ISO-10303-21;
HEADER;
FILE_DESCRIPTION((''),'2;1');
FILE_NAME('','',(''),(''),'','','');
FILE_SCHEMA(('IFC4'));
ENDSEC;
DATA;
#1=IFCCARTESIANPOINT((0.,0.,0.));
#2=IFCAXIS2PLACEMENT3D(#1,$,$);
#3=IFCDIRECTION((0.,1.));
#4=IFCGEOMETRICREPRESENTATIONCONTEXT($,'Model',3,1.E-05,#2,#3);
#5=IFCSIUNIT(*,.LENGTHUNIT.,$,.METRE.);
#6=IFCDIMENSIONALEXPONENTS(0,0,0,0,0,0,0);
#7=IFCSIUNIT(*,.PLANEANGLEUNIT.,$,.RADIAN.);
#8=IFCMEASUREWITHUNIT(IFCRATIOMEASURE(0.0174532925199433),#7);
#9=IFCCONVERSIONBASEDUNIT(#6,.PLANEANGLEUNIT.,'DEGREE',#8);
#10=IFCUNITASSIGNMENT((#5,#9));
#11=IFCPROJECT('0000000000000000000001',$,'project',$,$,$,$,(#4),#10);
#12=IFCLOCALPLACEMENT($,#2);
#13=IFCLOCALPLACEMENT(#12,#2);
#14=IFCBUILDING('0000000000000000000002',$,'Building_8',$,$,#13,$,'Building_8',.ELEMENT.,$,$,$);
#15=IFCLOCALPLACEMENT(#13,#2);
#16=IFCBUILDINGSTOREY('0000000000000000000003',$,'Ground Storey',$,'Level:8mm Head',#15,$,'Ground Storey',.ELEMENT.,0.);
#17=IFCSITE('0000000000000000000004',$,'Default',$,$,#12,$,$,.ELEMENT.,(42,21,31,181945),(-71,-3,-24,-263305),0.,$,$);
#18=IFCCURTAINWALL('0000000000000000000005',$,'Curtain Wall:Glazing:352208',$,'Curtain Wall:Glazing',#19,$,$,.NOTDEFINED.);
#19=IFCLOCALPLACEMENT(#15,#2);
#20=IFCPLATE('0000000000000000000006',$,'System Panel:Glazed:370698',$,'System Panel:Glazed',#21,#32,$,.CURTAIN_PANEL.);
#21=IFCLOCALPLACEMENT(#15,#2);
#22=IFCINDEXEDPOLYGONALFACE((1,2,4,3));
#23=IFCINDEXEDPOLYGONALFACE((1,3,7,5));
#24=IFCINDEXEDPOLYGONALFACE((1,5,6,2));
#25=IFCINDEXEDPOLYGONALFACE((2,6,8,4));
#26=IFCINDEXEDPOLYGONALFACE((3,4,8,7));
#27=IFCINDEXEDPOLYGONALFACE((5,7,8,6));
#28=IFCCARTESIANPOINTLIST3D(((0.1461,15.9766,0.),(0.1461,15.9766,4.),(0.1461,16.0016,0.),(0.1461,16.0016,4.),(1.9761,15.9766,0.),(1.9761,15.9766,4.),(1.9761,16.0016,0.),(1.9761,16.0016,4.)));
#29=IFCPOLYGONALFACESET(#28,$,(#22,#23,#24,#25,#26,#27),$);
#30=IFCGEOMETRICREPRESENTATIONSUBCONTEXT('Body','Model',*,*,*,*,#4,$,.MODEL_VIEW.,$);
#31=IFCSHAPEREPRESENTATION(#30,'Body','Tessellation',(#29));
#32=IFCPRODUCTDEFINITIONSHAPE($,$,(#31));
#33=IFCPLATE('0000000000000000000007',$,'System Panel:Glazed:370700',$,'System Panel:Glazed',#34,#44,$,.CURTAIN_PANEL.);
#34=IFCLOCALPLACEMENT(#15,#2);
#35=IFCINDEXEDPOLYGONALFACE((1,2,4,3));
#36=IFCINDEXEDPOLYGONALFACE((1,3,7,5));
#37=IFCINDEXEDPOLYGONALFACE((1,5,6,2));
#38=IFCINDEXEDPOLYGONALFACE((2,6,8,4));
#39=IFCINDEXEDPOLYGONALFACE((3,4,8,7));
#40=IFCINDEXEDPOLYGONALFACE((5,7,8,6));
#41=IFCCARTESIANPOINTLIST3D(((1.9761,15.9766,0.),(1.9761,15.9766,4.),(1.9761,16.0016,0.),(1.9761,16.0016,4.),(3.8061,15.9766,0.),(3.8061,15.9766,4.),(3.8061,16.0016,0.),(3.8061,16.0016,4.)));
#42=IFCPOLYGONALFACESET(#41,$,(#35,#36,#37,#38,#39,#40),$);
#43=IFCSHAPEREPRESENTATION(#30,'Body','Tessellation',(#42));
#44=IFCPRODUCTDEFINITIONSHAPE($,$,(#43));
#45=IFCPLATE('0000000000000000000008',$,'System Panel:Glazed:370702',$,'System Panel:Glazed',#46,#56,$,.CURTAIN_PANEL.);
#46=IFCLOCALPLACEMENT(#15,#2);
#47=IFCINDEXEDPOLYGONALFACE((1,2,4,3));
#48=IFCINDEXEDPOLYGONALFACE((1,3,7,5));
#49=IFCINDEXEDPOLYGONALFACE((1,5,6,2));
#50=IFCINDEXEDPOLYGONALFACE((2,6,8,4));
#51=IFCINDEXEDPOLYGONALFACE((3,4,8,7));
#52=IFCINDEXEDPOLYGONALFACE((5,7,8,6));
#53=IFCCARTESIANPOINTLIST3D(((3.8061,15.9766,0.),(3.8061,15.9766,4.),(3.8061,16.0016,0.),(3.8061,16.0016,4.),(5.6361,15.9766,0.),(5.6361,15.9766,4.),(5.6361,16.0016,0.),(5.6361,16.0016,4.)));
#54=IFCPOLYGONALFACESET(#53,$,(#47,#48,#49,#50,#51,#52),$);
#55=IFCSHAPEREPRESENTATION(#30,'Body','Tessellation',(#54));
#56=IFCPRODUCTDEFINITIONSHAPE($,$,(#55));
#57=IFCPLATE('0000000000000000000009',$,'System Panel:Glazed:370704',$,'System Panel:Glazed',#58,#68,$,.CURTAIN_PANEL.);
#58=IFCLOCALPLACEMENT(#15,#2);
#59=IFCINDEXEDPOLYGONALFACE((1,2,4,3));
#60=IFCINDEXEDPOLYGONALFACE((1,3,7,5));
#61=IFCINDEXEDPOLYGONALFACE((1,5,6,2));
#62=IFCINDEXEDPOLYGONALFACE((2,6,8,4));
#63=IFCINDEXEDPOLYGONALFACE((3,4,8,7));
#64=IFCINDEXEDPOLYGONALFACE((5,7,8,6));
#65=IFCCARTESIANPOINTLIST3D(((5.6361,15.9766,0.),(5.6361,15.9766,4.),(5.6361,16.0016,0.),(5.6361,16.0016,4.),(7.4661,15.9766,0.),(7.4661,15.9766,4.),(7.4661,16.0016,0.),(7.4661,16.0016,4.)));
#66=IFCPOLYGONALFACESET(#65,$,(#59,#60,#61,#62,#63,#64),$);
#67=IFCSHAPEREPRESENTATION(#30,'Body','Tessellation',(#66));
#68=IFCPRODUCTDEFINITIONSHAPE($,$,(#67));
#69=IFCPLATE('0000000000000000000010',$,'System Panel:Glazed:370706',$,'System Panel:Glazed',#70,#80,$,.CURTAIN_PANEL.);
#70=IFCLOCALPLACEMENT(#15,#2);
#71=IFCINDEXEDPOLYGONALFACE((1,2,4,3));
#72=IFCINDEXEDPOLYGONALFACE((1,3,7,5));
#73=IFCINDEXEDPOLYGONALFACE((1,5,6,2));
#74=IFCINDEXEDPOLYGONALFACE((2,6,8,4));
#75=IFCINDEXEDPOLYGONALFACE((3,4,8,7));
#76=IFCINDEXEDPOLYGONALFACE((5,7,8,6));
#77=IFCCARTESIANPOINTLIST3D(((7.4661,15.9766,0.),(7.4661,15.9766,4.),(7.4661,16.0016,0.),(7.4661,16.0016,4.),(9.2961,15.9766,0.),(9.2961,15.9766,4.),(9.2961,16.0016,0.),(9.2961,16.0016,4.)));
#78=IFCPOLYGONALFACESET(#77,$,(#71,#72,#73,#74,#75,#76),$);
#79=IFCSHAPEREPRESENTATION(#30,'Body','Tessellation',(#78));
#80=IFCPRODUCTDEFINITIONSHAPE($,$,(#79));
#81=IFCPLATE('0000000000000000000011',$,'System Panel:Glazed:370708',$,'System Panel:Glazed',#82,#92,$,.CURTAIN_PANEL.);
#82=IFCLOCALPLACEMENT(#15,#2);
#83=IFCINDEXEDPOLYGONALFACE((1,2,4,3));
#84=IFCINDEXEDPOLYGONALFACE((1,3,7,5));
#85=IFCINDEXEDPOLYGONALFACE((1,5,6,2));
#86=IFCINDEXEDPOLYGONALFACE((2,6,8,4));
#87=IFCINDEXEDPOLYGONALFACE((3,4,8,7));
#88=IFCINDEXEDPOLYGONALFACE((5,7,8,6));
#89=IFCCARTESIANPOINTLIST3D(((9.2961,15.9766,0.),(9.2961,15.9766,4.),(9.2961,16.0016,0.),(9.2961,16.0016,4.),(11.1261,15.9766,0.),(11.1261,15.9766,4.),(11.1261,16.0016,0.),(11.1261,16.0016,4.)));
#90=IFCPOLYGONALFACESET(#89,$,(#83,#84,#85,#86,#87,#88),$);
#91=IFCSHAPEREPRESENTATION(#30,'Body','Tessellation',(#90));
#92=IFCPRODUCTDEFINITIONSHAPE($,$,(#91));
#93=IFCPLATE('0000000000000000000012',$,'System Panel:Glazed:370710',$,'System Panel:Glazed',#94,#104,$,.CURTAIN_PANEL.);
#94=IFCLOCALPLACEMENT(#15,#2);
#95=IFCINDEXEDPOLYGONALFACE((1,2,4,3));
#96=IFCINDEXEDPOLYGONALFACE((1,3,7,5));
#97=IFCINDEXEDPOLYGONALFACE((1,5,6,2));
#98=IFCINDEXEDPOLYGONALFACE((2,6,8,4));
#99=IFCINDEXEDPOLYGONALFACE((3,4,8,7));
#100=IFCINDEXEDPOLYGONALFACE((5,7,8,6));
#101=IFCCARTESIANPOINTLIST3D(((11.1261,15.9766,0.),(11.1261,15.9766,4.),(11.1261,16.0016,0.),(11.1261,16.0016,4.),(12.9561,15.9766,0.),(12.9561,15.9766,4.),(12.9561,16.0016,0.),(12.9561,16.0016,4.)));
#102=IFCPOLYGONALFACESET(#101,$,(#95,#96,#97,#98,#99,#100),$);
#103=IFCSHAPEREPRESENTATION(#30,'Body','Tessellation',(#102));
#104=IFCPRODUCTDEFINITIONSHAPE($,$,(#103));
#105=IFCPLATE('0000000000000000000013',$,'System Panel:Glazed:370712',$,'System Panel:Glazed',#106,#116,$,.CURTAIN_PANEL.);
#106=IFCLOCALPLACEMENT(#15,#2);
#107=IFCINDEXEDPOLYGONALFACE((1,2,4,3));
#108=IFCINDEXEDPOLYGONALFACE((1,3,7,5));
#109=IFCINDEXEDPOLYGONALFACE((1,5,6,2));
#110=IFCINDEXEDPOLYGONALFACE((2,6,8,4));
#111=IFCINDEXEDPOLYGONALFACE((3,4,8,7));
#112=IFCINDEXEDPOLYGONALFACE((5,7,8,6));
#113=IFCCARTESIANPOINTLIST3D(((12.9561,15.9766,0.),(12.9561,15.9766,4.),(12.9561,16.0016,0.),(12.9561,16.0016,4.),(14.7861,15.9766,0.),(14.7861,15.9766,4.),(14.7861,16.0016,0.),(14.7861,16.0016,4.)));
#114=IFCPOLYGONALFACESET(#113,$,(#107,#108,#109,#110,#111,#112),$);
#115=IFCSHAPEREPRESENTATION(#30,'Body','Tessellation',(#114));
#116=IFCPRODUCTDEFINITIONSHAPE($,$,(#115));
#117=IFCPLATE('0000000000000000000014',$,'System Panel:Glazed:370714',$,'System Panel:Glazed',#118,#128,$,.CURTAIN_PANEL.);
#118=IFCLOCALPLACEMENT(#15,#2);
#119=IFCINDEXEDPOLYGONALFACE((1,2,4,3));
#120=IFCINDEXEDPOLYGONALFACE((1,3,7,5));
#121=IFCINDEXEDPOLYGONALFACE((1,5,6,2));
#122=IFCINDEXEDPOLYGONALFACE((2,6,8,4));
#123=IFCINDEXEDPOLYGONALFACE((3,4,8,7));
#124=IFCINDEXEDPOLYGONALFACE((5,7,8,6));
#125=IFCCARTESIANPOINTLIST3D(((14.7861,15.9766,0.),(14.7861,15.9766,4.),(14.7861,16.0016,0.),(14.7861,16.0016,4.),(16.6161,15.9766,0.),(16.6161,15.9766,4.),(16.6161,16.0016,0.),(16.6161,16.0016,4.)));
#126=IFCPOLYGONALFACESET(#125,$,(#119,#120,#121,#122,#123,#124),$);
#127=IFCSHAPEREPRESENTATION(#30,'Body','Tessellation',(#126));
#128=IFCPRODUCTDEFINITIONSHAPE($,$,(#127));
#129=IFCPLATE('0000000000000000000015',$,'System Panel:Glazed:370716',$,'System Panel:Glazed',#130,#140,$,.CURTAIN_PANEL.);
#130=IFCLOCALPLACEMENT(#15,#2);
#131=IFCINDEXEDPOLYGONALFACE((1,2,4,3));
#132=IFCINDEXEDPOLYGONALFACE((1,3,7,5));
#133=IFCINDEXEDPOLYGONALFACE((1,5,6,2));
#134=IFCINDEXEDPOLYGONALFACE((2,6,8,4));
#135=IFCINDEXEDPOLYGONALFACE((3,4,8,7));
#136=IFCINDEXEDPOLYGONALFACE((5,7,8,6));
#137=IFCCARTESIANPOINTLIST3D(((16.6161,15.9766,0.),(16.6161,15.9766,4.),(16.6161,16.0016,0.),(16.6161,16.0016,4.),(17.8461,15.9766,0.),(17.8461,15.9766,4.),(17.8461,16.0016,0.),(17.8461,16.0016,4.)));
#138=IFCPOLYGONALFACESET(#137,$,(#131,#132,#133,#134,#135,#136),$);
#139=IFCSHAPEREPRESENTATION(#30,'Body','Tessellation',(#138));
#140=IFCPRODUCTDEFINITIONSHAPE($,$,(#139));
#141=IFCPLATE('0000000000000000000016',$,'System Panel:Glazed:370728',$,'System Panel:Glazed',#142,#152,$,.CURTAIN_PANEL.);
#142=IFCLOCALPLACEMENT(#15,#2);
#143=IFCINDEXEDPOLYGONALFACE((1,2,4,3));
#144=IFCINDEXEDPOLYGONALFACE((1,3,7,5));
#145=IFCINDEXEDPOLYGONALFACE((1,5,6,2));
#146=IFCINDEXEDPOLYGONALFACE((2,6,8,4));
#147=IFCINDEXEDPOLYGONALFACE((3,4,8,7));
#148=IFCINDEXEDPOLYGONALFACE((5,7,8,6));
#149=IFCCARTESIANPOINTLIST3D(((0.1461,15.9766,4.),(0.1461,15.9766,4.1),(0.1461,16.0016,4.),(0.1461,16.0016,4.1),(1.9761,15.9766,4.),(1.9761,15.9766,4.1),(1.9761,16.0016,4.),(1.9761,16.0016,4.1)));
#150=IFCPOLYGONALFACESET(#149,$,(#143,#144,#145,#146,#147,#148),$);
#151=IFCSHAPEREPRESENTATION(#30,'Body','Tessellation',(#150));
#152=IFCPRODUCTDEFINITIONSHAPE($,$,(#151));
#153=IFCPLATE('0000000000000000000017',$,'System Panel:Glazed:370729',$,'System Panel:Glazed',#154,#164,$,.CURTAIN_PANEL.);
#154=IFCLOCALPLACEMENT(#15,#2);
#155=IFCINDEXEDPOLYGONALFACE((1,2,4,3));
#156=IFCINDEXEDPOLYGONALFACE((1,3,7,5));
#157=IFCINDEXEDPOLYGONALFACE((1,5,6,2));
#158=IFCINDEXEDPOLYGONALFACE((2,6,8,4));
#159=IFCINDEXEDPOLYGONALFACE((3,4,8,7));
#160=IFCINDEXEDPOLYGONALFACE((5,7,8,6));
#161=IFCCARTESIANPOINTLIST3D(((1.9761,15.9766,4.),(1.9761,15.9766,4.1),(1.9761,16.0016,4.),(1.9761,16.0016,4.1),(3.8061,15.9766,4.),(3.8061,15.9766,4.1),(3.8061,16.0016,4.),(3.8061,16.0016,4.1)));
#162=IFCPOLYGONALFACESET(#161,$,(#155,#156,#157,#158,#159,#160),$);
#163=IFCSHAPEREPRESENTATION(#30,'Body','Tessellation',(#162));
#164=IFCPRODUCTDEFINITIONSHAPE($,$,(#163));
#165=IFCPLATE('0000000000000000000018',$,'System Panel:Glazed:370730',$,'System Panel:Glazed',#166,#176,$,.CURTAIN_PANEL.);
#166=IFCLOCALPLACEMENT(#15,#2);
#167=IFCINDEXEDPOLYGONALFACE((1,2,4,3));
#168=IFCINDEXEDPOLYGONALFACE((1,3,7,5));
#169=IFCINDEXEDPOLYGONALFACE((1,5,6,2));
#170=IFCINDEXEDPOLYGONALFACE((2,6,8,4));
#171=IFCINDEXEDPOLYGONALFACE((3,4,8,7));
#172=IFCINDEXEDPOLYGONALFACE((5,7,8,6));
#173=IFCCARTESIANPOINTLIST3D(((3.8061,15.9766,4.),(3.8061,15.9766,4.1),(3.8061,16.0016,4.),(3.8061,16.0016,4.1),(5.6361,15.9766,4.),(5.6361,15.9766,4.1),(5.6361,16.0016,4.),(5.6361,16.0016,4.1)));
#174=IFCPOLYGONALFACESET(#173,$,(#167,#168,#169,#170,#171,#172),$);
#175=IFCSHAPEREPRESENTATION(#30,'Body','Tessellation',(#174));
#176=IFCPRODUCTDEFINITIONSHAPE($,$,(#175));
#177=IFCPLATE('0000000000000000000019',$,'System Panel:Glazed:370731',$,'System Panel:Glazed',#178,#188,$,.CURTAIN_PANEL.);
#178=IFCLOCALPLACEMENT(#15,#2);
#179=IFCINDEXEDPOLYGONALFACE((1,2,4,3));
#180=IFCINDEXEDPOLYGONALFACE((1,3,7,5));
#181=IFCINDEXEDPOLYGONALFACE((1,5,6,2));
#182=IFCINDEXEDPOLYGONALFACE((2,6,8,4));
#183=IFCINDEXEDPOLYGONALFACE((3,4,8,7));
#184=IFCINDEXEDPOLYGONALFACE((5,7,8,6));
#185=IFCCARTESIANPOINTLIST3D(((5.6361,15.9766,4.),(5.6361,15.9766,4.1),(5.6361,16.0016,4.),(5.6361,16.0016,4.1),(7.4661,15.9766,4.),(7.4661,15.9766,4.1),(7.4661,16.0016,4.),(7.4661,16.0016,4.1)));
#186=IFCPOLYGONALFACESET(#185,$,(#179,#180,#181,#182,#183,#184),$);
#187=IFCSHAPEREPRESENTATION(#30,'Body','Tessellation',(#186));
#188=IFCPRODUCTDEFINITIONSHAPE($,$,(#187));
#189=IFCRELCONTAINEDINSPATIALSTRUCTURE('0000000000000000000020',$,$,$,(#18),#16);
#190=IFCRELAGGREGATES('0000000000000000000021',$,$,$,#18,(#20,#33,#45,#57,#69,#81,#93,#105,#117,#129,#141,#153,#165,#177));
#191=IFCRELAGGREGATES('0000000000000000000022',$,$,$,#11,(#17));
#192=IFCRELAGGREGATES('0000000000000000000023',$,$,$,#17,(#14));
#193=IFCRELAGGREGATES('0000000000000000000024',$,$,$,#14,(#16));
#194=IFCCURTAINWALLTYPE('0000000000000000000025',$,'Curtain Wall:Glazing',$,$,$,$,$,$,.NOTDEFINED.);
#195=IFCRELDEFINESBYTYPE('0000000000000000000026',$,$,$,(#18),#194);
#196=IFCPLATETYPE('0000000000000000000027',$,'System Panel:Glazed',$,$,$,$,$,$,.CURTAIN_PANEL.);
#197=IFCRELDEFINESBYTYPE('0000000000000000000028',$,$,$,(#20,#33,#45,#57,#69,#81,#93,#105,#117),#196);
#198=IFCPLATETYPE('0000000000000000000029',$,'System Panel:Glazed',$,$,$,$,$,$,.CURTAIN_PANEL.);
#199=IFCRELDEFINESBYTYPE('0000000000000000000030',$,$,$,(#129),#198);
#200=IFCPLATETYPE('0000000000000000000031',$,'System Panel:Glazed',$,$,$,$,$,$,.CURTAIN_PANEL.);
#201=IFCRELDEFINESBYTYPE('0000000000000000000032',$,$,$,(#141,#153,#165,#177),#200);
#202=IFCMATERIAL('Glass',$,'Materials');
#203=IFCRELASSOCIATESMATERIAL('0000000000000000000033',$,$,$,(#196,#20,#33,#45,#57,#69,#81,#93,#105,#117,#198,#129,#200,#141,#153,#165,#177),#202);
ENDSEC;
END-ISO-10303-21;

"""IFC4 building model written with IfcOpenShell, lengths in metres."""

from ifc_helpers import new_model, entity, si_unit, converted_unit, direction, frame, origin, place, context, subcontext, project, spatial, indexed_curve, outline, extrude, source, transform, mapped, material, type_object, type_shapes, element, aggregate, save


model = new_model("IFC4")

# Units and contexts
model_context = context("Model", 3, precision=1e-05, world=origin(), true_north=direction((0.0, 1.0)))
body_context = subcontext(model_context, "Body", "Model", "MODEL_VIEW")
ifc_project = project(units=[si_unit("LENGTHUNIT", "METRE"), converted_unit("PLANEANGLEUNIT", "DEGREE", entity("IfcRatioMeasure", 0.0174532925199433), si_unit("PLANEANGLEUNIT", "RADIAN"), dimensions=[0, 0, 0, 0, 0, 0, 0])], contexts=[model_context])

# Site, building, storey
site_placement = place(None, origin())
site = spatial("IfcSite", under=ifc_project, at=site_placement, Name="Default", CompositionType="ELEMENT", RefLatitude=(42, 21, 31, 181945), RefLongitude=(-71, -3, -24, -263305), RefElevation=0.0)
building_placement = place(site_placement, origin())
building = spatial("IfcBuilding", under=site, at=building_placement, Name="Building_8", LongName="Building_8", CompositionType="ELEMENT")
storey_placement = place(building_placement, origin())
storey = spatial("IfcBuildingStorey", under=building, at=storey_placement, Name="Ground Storey", ObjectType="Level:8mm Head", LongName="Ground Storey", CompositionType="ELEMENT", Elevation=0.0)

# Curtain wall, plates
curtain_wall_type = type_object("IfcCurtainWallType", Name="Curtain Wall:Glazing", PredefinedType="NOTDEFINED")
curtain_wall_placement = place(storey_placement, origin())
curtain_wall = element("IfcCurtainWall", 1, at=curtain_wall_placement, inside=storey, type_object=curtain_wall_type, Name="Curtain Wall:Glazing:352208", ObjectType="Curtain Wall:Glazing", PredefinedType="NOTDEFINED")
ifc_material_1 = material(Name="Glass", Category="Materials")
plate_type_1 = type_object("IfcPlateType", Name="System Panel:Glazed", PredefinedType="CURTAIN_PANEL", material=ifc_material_1)
shared_shape_1 = source(origin(), body_context, "Body", "SweptSolid", [
    extrude(outline(indexed_curve([(-0.0125, -0.915), (0.0125, -0.915), (0.0125, 0.915), (-0.0125, 0.915), (-0.0125, -0.915)], self_intersect=False)), frame((0.0, 0.037, 0.0), z_axis=(0.0, 0.0, 1.0), x_axis=(0.0, 1.0, 0.0)), (0.0, 0.0, 1.0), 4.0),
])
type_shapes(plate_type_1, [shared_shape_1])
plate_1_placement = place(curtain_wall_placement, frame((1.0611, 15.9521, 0.0)))
plate_1 = element("IfcPlate", 2, at=plate_1_placement, type_object=plate_type_1, material=ifc_material_1, Name="System Panel:Glazed:370698", ObjectType="System Panel:Glazed", PredefinedType="CURTAIN_PANEL", context=body_context, shape_type="MappedRepresentation", body=[
    mapped(shared_shape_1, transform((0.0, 0.0, 0.0), scale=1.0)),
])
plate_2_placement = place(curtain_wall_placement, frame((2.8911, 15.9521, 0.0)))
plate_2 = element("IfcPlate", 3, at=plate_2_placement, type_object=plate_type_1, material=ifc_material_1, Name="System Panel:Glazed:370700", ObjectType="System Panel:Glazed", PredefinedType="CURTAIN_PANEL", context=body_context, shape_type="MappedRepresentation", body=[
    mapped(shared_shape_1, transform((0.0, 0.0, 0.0), scale=1.0)),
])
plate_3_placement = place(curtain_wall_placement, frame((4.7211, 15.9521, 0.0)))
plate_3 = element("IfcPlate", 4, at=plate_3_placement, type_object=plate_type_1, material=ifc_material_1, Name="System Panel:Glazed:370702", ObjectType="System Panel:Glazed", PredefinedType="CURTAIN_PANEL", context=body_context, shape_type="MappedRepresentation", body=[
    mapped(shared_shape_1, transform((0.0, 0.0, 0.0), scale=1.0)),
])
plate_4_placement = place(curtain_wall_placement, frame((6.5511, 15.9521, 0.0)))
plate_4 = element("IfcPlate", 5, at=plate_4_placement, type_object=plate_type_1, material=ifc_material_1, Name="System Panel:Glazed:370704", ObjectType="System Panel:Glazed", PredefinedType="CURTAIN_PANEL", context=body_context, shape_type="MappedRepresentation", body=[
    mapped(shared_shape_1, transform((0.0, 0.0, 0.0), scale=1.0)),
])
plate_5_placement = place(curtain_wall_placement, frame((8.3811, 15.9521, 0.0)))
plate_5 = element("IfcPlate", 6, at=plate_5_placement, type_object=plate_type_1, material=ifc_material_1, Name="System Panel:Glazed:370706", ObjectType="System Panel:Glazed", PredefinedType="CURTAIN_PANEL", context=body_context, shape_type="MappedRepresentation", body=[
    mapped(shared_shape_1, transform((0.0, 0.0, 0.0), scale=1.0)),
])
plate_6_placement = place(curtain_wall_placement, frame((10.2111, 15.9521, 0.0)))
plate_6 = element("IfcPlate", 7, at=plate_6_placement, type_object=plate_type_1, material=ifc_material_1, Name="System Panel:Glazed:370708", ObjectType="System Panel:Glazed", PredefinedType="CURTAIN_PANEL", context=body_context, shape_type="MappedRepresentation", body=[
    mapped(shared_shape_1, transform((0.0, 0.0, 0.0), scale=1.0)),
])
plate_7_placement = place(curtain_wall_placement, frame((12.0411, 15.9521, 0.0)))
plate_7 = element("IfcPlate", 8, at=plate_7_placement, type_object=plate_type_1, material=ifc_material_1, Name="System Panel:Glazed:370710", ObjectType="System Panel:Glazed", PredefinedType="CURTAIN_PANEL", context=body_context, shape_type="MappedRepresentation", body=[
    mapped(shared_shape_1, transform((0.0, 0.0, 0.0), scale=1.0)),
])
plate_8_placement = place(curtain_wall_placement, frame((13.8711, 15.9521, 0.0)))
plate_8 = element("IfcPlate", 9, at=plate_8_placement, type_object=plate_type_1, material=ifc_material_1, Name="System Panel:Glazed:370712", ObjectType="System Panel:Glazed", PredefinedType="CURTAIN_PANEL", context=body_context, shape_type="MappedRepresentation", body=[
    mapped(shared_shape_1, transform((0.0, 0.0, 0.0), scale=1.0)),
])
plate_9_placement = place(curtain_wall_placement, frame((15.7011, 15.9521, 0.0)))
plate_9 = element("IfcPlate", 10, at=plate_9_placement, type_object=plate_type_1, material=ifc_material_1, Name="System Panel:Glazed:370714", ObjectType="System Panel:Glazed", PredefinedType="CURTAIN_PANEL", context=body_context, shape_type="MappedRepresentation", body=[
    mapped(shared_shape_1, transform((0.0, 0.0, 0.0), scale=1.0)),
])
plate_type_2 = type_object("IfcPlateType", Name="System Panel:Glazed", PredefinedType="CURTAIN_PANEL", material=ifc_material_1)
shared_shape_2 = source(origin(), body_context, "Body", "SweptSolid", [
    extrude(outline(indexed_curve([(-0.0125, -0.615), (0.0125, -0.615), (0.0125, 0.615), (-0.0125, 0.615), (-0.0125, -0.615)], self_intersect=False)), frame((0.0, 0.037, 0.0), z_axis=(0.0, 0.0, 1.0), x_axis=(0.0, 1.0, 0.0)), (0.0, 0.0, 1.0), 4.0),
])
type_shapes(plate_type_2, [shared_shape_2])
plate_10_placement = place(curtain_wall_placement, frame((17.2311, 15.9521, 0.0)))
plate_10 = element("IfcPlate", 11, at=plate_10_placement, type_object=plate_type_2, material=ifc_material_1, Name="System Panel:Glazed:370716", ObjectType="System Panel:Glazed", PredefinedType="CURTAIN_PANEL", context=body_context, shape_type="MappedRepresentation", body=[
    mapped(shared_shape_2, transform((0.0, 0.0, 0.0), scale=1.0)),
])
plate_type_3 = type_object("IfcPlateType", Name="System Panel:Glazed", PredefinedType="CURTAIN_PANEL", material=ifc_material_1)
shared_shape_3 = source(origin(), body_context, "Body", "SweptSolid", [
    extrude(outline(indexed_curve([(-0.0125, -0.915), (0.0125, -0.915), (0.0125, 0.915), (-0.0125, 0.915), (-0.0125, -0.915)], self_intersect=False)), frame((0.0, 0.037, 0.0), z_axis=(0.0, 0.0, 1.0), x_axis=(0.0, 1.0, 0.0)), (0.0, 0.0, 1.0), 0.1),
])
type_shapes(plate_type_3, [shared_shape_3])
plate_11_placement = place(curtain_wall_placement, frame((1.0611, 15.9521, 4.0)))
plate_11 = element("IfcPlate", 12, at=plate_11_placement, type_object=plate_type_3, material=ifc_material_1, Name="System Panel:Glazed:370728", ObjectType="System Panel:Glazed", PredefinedType="CURTAIN_PANEL", context=body_context, shape_type="MappedRepresentation", body=[
    mapped(shared_shape_3, transform((0.0, 0.0, 0.0), scale=1.0)),
])
plate_12_placement = place(curtain_wall_placement, frame((2.8911, 15.9521, 4.0)))
plate_12 = element("IfcPlate", 13, at=plate_12_placement, type_object=plate_type_3, material=ifc_material_1, Name="System Panel:Glazed:370729", ObjectType="System Panel:Glazed", PredefinedType="CURTAIN_PANEL", context=body_context, shape_type="MappedRepresentation", body=[
    mapped(shared_shape_3, transform((0.0, 0.0, 0.0), scale=1.0)),
])
plate_13_placement = place(curtain_wall_placement, frame((4.7211, 15.9521, 4.0)))
plate_13 = element("IfcPlate", 14, at=plate_13_placement, type_object=plate_type_3, material=ifc_material_1, Name="System Panel:Glazed:370730", ObjectType="System Panel:Glazed", PredefinedType="CURTAIN_PANEL", context=body_context, shape_type="MappedRepresentation", body=[
    mapped(shared_shape_3, transform((0.0, 0.0, 0.0), scale=1.0)),
])
plate_14_placement = place(curtain_wall_placement, frame((6.5511, 15.9521, 4.0)))
plate_14 = element("IfcPlate", 15, at=plate_14_placement, type_object=plate_type_3, material=ifc_material_1, Name="System Panel:Glazed:370731", ObjectType="System Panel:Glazed", PredefinedType="CURTAIN_PANEL", context=body_context, shape_type="MappedRepresentation", body=[
    mapped(shared_shape_3, transform((0.0, 0.0, 0.0), scale=1.0)),
])
aggregate(curtain_wall, [plate_1, plate_2, plate_3, plate_4, plate_5, plate_6, plate_7, plate_8, plate_9, plate_10, plate_11, plate_12, plate_13, plate_14])

save(model, "model.ifc")
